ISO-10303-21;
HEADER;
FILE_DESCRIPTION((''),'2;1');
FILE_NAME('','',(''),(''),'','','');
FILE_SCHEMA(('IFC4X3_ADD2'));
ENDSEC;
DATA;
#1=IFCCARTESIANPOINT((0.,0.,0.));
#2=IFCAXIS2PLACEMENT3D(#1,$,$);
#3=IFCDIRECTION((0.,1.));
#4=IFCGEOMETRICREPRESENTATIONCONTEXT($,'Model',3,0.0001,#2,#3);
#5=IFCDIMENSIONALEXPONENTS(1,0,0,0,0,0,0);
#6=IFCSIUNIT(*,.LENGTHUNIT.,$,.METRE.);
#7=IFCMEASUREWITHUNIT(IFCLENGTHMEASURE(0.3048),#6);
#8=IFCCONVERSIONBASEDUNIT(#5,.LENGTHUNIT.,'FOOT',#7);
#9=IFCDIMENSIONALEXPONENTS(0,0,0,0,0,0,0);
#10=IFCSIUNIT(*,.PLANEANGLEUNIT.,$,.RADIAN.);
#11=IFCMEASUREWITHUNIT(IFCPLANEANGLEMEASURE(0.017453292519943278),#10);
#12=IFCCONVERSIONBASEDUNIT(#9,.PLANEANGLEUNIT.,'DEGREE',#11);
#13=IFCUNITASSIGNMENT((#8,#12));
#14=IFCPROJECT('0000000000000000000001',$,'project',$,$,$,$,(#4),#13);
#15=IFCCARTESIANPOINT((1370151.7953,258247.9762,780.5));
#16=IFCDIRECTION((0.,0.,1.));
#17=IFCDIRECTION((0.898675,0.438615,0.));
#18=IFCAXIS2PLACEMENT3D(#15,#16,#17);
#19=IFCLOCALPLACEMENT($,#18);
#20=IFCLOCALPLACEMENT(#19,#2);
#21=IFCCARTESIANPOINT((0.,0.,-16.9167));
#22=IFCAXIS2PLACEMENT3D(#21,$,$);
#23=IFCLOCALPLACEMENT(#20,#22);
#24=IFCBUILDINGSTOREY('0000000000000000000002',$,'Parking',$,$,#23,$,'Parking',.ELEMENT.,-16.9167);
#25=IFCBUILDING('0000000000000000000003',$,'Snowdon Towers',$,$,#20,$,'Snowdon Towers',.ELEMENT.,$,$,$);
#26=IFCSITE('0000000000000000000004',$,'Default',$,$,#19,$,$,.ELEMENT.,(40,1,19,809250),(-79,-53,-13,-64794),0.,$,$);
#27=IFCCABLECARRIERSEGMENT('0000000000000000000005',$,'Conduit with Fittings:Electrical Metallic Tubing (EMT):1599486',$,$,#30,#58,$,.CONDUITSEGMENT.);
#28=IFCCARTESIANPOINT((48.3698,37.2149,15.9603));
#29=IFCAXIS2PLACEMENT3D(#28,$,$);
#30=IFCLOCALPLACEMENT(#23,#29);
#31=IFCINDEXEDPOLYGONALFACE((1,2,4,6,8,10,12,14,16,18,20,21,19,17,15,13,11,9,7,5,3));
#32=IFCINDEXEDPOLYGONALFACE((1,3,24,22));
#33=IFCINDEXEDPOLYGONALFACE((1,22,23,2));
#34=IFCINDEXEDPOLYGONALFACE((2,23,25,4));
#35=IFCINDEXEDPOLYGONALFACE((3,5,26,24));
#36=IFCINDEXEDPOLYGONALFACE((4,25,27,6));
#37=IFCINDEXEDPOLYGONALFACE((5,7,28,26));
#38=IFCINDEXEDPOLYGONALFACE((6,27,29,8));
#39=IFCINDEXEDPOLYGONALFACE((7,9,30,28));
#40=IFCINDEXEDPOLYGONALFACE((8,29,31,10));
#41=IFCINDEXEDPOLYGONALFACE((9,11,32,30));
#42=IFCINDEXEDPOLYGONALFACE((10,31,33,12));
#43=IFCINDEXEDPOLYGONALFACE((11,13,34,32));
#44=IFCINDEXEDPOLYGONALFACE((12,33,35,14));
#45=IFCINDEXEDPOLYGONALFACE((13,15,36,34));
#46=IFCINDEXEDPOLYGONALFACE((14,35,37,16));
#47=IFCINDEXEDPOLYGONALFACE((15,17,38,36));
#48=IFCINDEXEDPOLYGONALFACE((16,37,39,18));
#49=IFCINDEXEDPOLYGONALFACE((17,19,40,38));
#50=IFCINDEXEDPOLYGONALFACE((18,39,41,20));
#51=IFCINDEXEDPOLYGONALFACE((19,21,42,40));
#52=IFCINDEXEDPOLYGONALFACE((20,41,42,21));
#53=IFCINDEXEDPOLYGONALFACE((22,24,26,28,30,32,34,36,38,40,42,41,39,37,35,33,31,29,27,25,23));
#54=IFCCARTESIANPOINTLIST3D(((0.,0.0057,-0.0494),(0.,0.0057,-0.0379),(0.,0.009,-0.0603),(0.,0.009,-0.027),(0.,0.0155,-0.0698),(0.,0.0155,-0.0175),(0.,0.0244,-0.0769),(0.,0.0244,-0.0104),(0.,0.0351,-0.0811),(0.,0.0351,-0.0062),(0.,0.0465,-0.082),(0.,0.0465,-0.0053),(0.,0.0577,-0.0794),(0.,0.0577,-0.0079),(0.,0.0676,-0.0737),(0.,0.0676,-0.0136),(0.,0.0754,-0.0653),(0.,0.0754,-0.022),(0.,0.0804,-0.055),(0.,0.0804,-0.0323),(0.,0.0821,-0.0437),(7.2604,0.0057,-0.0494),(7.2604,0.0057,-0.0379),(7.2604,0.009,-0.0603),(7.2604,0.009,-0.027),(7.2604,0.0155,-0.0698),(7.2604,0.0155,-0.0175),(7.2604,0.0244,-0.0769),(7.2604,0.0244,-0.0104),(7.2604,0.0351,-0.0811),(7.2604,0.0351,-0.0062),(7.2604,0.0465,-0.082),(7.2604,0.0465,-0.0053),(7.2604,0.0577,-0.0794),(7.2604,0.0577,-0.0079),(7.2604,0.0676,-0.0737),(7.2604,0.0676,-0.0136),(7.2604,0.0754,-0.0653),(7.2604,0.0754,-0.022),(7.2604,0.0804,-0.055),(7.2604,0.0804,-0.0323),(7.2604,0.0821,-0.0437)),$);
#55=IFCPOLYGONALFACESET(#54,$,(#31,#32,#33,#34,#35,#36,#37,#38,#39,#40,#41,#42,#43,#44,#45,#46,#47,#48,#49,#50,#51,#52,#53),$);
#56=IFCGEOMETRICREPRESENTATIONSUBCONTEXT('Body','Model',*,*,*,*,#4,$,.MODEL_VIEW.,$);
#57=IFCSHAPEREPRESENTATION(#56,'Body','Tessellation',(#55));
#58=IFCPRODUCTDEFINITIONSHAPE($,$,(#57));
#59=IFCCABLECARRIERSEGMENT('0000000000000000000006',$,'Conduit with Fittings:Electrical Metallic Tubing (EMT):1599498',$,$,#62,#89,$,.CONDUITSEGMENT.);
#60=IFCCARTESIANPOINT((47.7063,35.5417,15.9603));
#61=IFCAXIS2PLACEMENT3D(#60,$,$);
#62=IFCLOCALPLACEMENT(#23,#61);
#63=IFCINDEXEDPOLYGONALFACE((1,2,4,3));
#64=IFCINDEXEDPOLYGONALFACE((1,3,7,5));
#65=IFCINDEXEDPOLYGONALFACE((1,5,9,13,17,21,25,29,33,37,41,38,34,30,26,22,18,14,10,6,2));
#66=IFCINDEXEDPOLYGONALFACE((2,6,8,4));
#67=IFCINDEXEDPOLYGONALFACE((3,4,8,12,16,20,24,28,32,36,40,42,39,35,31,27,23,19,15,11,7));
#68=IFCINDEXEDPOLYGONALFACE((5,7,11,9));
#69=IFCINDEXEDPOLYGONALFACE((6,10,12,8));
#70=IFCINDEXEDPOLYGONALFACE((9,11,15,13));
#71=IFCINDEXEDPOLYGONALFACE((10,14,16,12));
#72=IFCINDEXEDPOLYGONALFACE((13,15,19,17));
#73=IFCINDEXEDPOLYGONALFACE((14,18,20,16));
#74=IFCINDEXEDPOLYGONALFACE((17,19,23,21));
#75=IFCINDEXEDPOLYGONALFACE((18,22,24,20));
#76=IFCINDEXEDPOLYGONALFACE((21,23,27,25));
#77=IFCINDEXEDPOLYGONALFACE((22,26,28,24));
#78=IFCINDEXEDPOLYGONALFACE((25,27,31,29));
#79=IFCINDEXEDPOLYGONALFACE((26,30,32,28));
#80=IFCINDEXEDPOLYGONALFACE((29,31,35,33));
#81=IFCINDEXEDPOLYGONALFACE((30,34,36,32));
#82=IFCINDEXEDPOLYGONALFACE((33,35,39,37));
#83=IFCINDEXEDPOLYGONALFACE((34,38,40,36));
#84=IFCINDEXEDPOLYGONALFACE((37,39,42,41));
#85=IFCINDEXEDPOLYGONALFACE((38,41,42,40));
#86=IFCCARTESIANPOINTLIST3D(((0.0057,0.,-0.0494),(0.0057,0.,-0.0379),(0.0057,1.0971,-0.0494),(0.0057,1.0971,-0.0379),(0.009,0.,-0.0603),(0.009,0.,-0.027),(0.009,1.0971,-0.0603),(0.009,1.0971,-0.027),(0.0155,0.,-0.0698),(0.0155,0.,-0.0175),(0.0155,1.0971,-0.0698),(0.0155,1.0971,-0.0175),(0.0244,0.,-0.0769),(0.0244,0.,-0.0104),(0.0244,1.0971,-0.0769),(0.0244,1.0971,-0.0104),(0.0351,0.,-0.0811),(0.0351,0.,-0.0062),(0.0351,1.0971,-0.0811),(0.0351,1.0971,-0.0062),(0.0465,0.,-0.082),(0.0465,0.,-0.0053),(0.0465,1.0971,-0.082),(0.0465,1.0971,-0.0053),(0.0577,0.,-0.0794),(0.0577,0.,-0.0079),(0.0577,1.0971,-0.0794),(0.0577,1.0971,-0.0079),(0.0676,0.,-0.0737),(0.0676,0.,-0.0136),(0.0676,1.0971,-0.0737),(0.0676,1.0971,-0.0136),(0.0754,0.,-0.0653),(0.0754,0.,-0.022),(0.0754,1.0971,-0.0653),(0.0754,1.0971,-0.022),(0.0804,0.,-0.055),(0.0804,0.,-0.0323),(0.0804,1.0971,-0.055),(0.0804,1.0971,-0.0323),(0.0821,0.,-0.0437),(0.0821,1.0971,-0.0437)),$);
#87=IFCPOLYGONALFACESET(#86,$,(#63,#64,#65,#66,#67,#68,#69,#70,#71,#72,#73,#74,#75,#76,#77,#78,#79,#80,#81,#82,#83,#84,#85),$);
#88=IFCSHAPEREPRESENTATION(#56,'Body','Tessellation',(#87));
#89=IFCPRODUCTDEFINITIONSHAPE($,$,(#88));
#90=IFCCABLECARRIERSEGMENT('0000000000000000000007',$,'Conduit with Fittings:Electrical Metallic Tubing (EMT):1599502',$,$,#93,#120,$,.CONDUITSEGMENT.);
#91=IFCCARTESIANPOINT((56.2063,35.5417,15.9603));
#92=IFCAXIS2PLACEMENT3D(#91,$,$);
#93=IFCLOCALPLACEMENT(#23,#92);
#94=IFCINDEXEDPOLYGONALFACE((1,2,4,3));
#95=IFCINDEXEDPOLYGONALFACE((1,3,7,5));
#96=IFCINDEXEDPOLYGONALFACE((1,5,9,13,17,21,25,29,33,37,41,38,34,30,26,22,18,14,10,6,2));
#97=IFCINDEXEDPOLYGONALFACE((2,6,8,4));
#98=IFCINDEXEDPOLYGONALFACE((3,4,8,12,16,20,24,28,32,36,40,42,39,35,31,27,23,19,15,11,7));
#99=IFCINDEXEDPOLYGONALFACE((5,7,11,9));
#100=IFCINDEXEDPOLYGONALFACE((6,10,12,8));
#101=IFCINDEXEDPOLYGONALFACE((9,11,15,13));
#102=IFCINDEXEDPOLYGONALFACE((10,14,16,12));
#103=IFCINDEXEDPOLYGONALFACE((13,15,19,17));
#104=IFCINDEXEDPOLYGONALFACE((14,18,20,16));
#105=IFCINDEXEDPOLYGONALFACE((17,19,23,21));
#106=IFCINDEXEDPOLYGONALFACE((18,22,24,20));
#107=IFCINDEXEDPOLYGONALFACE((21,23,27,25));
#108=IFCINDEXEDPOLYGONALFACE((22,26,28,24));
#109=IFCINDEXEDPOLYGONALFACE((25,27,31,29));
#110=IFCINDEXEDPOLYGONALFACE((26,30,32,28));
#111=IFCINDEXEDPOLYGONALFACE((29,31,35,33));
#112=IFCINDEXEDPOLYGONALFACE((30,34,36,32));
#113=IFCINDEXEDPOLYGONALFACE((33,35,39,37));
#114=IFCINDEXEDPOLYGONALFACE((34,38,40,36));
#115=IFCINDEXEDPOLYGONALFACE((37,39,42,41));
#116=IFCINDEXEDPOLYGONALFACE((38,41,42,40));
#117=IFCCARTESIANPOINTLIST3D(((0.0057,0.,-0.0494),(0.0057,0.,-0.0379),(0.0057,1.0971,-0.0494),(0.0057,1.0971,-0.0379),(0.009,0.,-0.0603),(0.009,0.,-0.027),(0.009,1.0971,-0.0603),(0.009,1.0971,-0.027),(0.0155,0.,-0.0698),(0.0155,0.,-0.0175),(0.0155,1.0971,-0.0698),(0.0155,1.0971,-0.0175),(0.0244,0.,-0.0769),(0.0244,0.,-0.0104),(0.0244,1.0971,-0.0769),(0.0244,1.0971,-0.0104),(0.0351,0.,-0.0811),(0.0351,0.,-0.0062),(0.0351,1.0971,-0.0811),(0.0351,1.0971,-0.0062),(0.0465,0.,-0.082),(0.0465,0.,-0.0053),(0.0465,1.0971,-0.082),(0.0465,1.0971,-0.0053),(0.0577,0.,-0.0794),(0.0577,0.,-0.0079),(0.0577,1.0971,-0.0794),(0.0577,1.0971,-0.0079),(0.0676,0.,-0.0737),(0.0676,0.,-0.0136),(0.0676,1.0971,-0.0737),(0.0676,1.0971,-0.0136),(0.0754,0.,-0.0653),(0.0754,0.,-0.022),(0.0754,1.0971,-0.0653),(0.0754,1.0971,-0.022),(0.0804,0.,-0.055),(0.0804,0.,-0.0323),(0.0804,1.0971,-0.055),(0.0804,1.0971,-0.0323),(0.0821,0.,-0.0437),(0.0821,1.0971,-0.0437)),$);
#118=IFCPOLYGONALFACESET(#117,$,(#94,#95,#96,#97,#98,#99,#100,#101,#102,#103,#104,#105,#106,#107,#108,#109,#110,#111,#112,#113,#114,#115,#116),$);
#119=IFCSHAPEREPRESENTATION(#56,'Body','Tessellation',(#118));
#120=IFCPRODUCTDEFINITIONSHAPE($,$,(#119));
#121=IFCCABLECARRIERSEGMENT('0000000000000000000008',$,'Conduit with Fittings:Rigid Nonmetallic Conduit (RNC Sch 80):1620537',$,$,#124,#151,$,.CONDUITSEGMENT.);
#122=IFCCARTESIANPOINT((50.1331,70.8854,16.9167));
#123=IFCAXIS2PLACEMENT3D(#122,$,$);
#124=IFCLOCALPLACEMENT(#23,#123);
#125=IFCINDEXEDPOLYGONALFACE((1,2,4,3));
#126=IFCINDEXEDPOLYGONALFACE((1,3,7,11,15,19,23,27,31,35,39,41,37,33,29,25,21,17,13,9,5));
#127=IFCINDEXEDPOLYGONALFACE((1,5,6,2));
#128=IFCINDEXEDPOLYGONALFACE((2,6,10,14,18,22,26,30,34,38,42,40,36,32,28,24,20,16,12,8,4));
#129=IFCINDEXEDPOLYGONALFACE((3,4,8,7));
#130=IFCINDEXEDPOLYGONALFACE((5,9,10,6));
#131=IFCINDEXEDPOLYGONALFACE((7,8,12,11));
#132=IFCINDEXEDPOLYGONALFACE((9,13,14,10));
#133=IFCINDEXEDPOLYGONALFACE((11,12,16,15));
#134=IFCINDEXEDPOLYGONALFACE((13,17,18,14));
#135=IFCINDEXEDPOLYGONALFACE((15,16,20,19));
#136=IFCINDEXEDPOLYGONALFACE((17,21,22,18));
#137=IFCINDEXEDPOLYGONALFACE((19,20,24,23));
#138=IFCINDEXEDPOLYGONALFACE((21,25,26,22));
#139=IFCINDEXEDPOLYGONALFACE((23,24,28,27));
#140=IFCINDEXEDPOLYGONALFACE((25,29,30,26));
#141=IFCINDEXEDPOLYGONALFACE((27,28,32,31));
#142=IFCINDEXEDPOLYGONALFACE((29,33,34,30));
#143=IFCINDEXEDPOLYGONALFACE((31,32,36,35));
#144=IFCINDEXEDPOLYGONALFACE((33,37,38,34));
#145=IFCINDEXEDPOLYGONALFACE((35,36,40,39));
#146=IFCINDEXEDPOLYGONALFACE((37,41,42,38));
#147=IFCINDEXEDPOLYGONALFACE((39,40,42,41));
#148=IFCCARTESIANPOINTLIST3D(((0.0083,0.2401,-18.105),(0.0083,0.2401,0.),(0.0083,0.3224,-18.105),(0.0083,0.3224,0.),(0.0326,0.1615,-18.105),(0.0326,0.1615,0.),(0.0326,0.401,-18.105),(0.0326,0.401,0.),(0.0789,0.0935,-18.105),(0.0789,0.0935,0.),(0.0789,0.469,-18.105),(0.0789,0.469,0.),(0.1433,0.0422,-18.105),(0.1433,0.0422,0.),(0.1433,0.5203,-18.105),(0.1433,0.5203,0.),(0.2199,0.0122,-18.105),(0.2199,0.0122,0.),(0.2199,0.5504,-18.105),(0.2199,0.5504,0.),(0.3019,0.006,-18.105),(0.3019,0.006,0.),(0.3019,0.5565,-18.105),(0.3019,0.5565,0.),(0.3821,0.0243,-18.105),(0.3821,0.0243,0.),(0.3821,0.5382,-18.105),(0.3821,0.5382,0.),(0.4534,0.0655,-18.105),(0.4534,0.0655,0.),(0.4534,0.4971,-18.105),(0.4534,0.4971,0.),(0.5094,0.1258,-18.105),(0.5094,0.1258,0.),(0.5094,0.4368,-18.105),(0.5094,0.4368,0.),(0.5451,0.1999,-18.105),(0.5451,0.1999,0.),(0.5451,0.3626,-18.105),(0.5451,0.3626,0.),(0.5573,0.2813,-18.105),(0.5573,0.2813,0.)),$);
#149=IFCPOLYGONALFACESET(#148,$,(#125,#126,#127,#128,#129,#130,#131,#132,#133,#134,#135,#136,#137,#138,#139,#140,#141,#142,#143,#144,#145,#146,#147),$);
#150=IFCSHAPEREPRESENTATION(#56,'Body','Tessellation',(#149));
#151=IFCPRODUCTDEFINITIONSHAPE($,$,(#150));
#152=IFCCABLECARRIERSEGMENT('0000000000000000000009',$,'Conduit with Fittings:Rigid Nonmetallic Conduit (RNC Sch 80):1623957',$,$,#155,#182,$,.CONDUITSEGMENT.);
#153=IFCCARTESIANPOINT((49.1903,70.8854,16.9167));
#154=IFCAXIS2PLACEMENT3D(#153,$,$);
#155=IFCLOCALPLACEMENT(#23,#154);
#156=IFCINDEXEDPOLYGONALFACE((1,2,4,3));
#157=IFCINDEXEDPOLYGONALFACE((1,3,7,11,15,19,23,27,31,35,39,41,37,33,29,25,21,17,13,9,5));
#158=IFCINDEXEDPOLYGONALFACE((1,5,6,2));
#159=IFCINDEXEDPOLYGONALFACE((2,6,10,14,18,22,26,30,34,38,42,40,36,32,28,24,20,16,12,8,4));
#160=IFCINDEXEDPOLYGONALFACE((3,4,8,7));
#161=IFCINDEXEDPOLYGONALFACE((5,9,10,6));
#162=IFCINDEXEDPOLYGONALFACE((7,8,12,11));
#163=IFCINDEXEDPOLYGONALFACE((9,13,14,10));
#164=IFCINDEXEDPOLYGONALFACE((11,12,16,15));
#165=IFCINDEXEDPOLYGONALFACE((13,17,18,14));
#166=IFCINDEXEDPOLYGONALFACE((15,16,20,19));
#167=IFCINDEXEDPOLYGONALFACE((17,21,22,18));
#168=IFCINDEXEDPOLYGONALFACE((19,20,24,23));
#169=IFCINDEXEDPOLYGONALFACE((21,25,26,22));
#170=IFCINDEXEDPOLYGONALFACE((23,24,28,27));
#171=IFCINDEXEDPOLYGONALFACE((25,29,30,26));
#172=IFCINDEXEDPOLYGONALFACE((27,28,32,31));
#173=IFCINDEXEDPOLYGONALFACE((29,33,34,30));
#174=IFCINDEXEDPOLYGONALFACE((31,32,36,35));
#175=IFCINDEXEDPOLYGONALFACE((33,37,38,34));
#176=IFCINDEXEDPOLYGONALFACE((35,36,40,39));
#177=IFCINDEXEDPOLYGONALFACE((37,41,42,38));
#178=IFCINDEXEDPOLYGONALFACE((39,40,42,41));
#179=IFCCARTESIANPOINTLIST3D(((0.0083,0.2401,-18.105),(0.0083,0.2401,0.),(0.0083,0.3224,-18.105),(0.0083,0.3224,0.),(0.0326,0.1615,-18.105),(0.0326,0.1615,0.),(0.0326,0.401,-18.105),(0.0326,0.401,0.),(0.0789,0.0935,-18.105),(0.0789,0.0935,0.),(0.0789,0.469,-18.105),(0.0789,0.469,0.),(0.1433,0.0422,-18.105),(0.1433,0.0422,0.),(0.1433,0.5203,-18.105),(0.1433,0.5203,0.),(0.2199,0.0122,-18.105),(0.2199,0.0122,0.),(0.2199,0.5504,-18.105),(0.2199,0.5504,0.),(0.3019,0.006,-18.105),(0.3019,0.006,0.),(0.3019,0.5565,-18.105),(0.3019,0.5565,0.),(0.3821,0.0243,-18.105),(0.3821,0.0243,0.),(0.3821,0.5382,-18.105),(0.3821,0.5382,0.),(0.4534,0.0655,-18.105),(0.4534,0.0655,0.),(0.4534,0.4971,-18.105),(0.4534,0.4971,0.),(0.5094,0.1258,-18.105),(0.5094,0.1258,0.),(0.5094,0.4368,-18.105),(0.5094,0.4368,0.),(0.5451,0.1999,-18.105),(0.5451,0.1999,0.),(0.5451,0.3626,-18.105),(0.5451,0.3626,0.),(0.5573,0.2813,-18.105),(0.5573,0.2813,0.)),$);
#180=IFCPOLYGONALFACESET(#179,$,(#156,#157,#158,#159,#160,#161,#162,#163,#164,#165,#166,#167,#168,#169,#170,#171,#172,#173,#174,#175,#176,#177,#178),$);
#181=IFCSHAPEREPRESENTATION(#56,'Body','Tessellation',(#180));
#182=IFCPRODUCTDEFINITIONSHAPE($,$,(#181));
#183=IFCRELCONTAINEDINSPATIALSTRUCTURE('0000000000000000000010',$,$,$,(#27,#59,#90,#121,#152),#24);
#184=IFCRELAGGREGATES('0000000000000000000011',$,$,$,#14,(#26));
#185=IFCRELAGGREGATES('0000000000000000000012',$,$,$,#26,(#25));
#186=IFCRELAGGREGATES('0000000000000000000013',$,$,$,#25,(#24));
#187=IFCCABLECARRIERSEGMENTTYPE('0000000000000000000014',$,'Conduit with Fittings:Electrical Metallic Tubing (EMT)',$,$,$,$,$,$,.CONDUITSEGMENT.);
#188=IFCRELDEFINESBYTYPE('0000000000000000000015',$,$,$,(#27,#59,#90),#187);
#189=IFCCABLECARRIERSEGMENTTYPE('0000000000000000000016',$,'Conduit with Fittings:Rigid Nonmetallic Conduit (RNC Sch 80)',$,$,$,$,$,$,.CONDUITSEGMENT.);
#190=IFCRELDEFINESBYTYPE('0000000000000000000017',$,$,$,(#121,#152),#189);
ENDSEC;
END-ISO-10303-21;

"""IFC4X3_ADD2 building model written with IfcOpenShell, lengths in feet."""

from ifc_helpers import new_model, entity, si_unit, converted_unit, direction, frame, frame_2d, origin, origin_2d_with_axis, place, context, subcontext, project, spatial, circle, extrude, type_object, element, save


model = new_model("IFC4X3_ADD2")

# Units and contexts
model_context = context("Model", 3, precision=0.0001, world=origin(), true_north=direction((0.0, 1.0)))
body_context = subcontext(model_context, "Body", "Model", "MODEL_VIEW")
ifc_project = project(units=[converted_unit("LENGTHUNIT", "FOOT", entity("IfcLengthMeasure", 0.3048), si_unit("LENGTHUNIT", "METRE"), dimensions=[1, 0, 0, 0, 0, 0, 0]), converted_unit("PLANEANGLEUNIT", "DEGREE", entity("IfcPlaneAngleMeasure", 0.017453292519943278), si_unit("PLANEANGLEUNIT", "RADIAN"), dimensions=[0, 0, 0, 0, 0, 0, 0])], contexts=[model_context])

# Site, building, storey
site_placement = place(None, frame((1370151.7953, 258247.9762, 780.5), z_axis=(0.0, 0.0, 1.0), x_axis=(0.898675, 0.438615, 0.0)))
site = spatial("IfcSite", under=ifc_project, at=site_placement, Name="Default", CompositionType="ELEMENT", RefLatitude=(40, 1, 19, 809250), RefLongitude=(-79, -53, -13, -64794), RefElevation=0.0)
building_placement = place(site_placement, origin())
building = spatial("IfcBuilding", under=site, at=building_placement, Name="Snowdon Towers", LongName="Snowdon Towers", CompositionType="ELEMENT")
storey_placement = place(building_placement, frame((0.0, 0.0, -16.9167)))
storey = spatial("IfcBuildingStorey", under=building, at=storey_placement, Name="Parking", LongName="Parking", CompositionType="ELEMENT", Elevation=-16.9167)

# Cable carrier segments
cable_carrier_segment_type_1 = type_object("IfcCableCarrierSegmentType", Name="Conduit with Fittings:Electrical Metallic Tubing (EMT)", PredefinedType="CONDUITSEGMENT")
cable_carrier_segment_1_placement = place(storey_placement, frame((48.3698, 37.2149, 15.9603)))
element("IfcCableCarrierSegment", 1, at=cable_carrier_segment_1_placement, inside=storey, type_object=cable_carrier_segment_type_1, Name="Conduit with Fittings:Electrical Metallic Tubing (EMT):1599486", PredefinedType="CONDUITSEGMENT", context=body_context, shape_type="SweptSolid", body=[
    extrude(circle(Radius=0.0384, at=frame_2d((0.0, 0.0), x_axis=(1.0, 0.0))), frame((0.0, 0.0437, -0.0437), z_axis=(1.0, 0.0, 0.0), x_axis=(0.0, 1.0, 0.0)), (0.0, 0.0, 1.0), 7.2604),
])
cable_carrier_segment_2_placement = place(storey_placement, frame((47.7063, 35.5417, 15.9603)))
element("IfcCableCarrierSegment", 2, at=cable_carrier_segment_2_placement, inside=storey, type_object=cable_carrier_segment_type_1, Name="Conduit with Fittings:Electrical Metallic Tubing (EMT):1599498", PredefinedType="CONDUITSEGMENT", context=body_context, shape_type="SweptSolid", body=[
    extrude(circle(Radius=0.0384, at=frame_2d((0.0, 0.0), x_axis=(1.0, 0.0))), frame((0.0437, 0.0, -0.0437), z_axis=(0.0, 1.0, 0.0), x_axis=(1.0, 0.0, 0.0)), (0.0, 0.0, 1.0), 1.0971),
])
cable_carrier_segment_3_placement = place(storey_placement, frame((56.2063, 35.5417, 15.9603)))
element("IfcCableCarrierSegment", 3, at=cable_carrier_segment_3_placement, inside=storey, type_object=cable_carrier_segment_type_1, Name="Conduit with Fittings:Electrical Metallic Tubing (EMT):1599502", PredefinedType="CONDUITSEGMENT", context=body_context, shape_type="SweptSolid", body=[
    extrude(circle(Radius=0.0384, at=frame_2d((0.0, 0.0), x_axis=(1.0, 0.0))), frame((0.0437, 0.0, -0.0437), z_axis=(0.0, 1.0, 0.0), x_axis=(1.0, 0.0, 0.0)), (0.0, 0.0, 1.0), 1.0971),
])

# Cable carrier segments
cable_carrier_segment_type_2 = type_object("IfcCableCarrierSegmentType", Name="Conduit with Fittings:Rigid Nonmetallic Conduit (RNC Sch 80)", PredefinedType="CONDUITSEGMENT")
cable_carrier_segment_4_placement = place(storey_placement, frame((50.1331, 70.8854, 16.9167)))
element("IfcCableCarrierSegment", 4, at=cable_carrier_segment_4_placement, inside=storey, type_object=cable_carrier_segment_type_2, Name="Conduit with Fittings:Rigid Nonmetallic Conduit (RNC Sch 80):1620537", PredefinedType="CONDUITSEGMENT", context=body_context, shape_type="SweptSolid", body=[
    extrude(circle(Radius=0.276, at=origin_2d_with_axis()), frame((0.2813, 0.2813, -18.105)), (0.0, 0.0, 1.0), 18.105),
])
cable_carrier_segment_5_placement = place(storey_placement, frame((49.1903, 70.8854, 16.9167)))
element("IfcCableCarrierSegment", 5, at=cable_carrier_segment_5_placement, inside=storey, type_object=cable_carrier_segment_type_2, Name="Conduit with Fittings:Rigid Nonmetallic Conduit (RNC Sch 80):1623957", PredefinedType="CONDUITSEGMENT", context=body_context, shape_type="SweptSolid", body=[
    extrude(circle(Radius=0.276, at=origin_2d_with_axis()), frame((0.2813, 0.2813, -18.105)), (0.0, 0.0, 1.0), 18.105),
])

save(model, "model.ifc")
